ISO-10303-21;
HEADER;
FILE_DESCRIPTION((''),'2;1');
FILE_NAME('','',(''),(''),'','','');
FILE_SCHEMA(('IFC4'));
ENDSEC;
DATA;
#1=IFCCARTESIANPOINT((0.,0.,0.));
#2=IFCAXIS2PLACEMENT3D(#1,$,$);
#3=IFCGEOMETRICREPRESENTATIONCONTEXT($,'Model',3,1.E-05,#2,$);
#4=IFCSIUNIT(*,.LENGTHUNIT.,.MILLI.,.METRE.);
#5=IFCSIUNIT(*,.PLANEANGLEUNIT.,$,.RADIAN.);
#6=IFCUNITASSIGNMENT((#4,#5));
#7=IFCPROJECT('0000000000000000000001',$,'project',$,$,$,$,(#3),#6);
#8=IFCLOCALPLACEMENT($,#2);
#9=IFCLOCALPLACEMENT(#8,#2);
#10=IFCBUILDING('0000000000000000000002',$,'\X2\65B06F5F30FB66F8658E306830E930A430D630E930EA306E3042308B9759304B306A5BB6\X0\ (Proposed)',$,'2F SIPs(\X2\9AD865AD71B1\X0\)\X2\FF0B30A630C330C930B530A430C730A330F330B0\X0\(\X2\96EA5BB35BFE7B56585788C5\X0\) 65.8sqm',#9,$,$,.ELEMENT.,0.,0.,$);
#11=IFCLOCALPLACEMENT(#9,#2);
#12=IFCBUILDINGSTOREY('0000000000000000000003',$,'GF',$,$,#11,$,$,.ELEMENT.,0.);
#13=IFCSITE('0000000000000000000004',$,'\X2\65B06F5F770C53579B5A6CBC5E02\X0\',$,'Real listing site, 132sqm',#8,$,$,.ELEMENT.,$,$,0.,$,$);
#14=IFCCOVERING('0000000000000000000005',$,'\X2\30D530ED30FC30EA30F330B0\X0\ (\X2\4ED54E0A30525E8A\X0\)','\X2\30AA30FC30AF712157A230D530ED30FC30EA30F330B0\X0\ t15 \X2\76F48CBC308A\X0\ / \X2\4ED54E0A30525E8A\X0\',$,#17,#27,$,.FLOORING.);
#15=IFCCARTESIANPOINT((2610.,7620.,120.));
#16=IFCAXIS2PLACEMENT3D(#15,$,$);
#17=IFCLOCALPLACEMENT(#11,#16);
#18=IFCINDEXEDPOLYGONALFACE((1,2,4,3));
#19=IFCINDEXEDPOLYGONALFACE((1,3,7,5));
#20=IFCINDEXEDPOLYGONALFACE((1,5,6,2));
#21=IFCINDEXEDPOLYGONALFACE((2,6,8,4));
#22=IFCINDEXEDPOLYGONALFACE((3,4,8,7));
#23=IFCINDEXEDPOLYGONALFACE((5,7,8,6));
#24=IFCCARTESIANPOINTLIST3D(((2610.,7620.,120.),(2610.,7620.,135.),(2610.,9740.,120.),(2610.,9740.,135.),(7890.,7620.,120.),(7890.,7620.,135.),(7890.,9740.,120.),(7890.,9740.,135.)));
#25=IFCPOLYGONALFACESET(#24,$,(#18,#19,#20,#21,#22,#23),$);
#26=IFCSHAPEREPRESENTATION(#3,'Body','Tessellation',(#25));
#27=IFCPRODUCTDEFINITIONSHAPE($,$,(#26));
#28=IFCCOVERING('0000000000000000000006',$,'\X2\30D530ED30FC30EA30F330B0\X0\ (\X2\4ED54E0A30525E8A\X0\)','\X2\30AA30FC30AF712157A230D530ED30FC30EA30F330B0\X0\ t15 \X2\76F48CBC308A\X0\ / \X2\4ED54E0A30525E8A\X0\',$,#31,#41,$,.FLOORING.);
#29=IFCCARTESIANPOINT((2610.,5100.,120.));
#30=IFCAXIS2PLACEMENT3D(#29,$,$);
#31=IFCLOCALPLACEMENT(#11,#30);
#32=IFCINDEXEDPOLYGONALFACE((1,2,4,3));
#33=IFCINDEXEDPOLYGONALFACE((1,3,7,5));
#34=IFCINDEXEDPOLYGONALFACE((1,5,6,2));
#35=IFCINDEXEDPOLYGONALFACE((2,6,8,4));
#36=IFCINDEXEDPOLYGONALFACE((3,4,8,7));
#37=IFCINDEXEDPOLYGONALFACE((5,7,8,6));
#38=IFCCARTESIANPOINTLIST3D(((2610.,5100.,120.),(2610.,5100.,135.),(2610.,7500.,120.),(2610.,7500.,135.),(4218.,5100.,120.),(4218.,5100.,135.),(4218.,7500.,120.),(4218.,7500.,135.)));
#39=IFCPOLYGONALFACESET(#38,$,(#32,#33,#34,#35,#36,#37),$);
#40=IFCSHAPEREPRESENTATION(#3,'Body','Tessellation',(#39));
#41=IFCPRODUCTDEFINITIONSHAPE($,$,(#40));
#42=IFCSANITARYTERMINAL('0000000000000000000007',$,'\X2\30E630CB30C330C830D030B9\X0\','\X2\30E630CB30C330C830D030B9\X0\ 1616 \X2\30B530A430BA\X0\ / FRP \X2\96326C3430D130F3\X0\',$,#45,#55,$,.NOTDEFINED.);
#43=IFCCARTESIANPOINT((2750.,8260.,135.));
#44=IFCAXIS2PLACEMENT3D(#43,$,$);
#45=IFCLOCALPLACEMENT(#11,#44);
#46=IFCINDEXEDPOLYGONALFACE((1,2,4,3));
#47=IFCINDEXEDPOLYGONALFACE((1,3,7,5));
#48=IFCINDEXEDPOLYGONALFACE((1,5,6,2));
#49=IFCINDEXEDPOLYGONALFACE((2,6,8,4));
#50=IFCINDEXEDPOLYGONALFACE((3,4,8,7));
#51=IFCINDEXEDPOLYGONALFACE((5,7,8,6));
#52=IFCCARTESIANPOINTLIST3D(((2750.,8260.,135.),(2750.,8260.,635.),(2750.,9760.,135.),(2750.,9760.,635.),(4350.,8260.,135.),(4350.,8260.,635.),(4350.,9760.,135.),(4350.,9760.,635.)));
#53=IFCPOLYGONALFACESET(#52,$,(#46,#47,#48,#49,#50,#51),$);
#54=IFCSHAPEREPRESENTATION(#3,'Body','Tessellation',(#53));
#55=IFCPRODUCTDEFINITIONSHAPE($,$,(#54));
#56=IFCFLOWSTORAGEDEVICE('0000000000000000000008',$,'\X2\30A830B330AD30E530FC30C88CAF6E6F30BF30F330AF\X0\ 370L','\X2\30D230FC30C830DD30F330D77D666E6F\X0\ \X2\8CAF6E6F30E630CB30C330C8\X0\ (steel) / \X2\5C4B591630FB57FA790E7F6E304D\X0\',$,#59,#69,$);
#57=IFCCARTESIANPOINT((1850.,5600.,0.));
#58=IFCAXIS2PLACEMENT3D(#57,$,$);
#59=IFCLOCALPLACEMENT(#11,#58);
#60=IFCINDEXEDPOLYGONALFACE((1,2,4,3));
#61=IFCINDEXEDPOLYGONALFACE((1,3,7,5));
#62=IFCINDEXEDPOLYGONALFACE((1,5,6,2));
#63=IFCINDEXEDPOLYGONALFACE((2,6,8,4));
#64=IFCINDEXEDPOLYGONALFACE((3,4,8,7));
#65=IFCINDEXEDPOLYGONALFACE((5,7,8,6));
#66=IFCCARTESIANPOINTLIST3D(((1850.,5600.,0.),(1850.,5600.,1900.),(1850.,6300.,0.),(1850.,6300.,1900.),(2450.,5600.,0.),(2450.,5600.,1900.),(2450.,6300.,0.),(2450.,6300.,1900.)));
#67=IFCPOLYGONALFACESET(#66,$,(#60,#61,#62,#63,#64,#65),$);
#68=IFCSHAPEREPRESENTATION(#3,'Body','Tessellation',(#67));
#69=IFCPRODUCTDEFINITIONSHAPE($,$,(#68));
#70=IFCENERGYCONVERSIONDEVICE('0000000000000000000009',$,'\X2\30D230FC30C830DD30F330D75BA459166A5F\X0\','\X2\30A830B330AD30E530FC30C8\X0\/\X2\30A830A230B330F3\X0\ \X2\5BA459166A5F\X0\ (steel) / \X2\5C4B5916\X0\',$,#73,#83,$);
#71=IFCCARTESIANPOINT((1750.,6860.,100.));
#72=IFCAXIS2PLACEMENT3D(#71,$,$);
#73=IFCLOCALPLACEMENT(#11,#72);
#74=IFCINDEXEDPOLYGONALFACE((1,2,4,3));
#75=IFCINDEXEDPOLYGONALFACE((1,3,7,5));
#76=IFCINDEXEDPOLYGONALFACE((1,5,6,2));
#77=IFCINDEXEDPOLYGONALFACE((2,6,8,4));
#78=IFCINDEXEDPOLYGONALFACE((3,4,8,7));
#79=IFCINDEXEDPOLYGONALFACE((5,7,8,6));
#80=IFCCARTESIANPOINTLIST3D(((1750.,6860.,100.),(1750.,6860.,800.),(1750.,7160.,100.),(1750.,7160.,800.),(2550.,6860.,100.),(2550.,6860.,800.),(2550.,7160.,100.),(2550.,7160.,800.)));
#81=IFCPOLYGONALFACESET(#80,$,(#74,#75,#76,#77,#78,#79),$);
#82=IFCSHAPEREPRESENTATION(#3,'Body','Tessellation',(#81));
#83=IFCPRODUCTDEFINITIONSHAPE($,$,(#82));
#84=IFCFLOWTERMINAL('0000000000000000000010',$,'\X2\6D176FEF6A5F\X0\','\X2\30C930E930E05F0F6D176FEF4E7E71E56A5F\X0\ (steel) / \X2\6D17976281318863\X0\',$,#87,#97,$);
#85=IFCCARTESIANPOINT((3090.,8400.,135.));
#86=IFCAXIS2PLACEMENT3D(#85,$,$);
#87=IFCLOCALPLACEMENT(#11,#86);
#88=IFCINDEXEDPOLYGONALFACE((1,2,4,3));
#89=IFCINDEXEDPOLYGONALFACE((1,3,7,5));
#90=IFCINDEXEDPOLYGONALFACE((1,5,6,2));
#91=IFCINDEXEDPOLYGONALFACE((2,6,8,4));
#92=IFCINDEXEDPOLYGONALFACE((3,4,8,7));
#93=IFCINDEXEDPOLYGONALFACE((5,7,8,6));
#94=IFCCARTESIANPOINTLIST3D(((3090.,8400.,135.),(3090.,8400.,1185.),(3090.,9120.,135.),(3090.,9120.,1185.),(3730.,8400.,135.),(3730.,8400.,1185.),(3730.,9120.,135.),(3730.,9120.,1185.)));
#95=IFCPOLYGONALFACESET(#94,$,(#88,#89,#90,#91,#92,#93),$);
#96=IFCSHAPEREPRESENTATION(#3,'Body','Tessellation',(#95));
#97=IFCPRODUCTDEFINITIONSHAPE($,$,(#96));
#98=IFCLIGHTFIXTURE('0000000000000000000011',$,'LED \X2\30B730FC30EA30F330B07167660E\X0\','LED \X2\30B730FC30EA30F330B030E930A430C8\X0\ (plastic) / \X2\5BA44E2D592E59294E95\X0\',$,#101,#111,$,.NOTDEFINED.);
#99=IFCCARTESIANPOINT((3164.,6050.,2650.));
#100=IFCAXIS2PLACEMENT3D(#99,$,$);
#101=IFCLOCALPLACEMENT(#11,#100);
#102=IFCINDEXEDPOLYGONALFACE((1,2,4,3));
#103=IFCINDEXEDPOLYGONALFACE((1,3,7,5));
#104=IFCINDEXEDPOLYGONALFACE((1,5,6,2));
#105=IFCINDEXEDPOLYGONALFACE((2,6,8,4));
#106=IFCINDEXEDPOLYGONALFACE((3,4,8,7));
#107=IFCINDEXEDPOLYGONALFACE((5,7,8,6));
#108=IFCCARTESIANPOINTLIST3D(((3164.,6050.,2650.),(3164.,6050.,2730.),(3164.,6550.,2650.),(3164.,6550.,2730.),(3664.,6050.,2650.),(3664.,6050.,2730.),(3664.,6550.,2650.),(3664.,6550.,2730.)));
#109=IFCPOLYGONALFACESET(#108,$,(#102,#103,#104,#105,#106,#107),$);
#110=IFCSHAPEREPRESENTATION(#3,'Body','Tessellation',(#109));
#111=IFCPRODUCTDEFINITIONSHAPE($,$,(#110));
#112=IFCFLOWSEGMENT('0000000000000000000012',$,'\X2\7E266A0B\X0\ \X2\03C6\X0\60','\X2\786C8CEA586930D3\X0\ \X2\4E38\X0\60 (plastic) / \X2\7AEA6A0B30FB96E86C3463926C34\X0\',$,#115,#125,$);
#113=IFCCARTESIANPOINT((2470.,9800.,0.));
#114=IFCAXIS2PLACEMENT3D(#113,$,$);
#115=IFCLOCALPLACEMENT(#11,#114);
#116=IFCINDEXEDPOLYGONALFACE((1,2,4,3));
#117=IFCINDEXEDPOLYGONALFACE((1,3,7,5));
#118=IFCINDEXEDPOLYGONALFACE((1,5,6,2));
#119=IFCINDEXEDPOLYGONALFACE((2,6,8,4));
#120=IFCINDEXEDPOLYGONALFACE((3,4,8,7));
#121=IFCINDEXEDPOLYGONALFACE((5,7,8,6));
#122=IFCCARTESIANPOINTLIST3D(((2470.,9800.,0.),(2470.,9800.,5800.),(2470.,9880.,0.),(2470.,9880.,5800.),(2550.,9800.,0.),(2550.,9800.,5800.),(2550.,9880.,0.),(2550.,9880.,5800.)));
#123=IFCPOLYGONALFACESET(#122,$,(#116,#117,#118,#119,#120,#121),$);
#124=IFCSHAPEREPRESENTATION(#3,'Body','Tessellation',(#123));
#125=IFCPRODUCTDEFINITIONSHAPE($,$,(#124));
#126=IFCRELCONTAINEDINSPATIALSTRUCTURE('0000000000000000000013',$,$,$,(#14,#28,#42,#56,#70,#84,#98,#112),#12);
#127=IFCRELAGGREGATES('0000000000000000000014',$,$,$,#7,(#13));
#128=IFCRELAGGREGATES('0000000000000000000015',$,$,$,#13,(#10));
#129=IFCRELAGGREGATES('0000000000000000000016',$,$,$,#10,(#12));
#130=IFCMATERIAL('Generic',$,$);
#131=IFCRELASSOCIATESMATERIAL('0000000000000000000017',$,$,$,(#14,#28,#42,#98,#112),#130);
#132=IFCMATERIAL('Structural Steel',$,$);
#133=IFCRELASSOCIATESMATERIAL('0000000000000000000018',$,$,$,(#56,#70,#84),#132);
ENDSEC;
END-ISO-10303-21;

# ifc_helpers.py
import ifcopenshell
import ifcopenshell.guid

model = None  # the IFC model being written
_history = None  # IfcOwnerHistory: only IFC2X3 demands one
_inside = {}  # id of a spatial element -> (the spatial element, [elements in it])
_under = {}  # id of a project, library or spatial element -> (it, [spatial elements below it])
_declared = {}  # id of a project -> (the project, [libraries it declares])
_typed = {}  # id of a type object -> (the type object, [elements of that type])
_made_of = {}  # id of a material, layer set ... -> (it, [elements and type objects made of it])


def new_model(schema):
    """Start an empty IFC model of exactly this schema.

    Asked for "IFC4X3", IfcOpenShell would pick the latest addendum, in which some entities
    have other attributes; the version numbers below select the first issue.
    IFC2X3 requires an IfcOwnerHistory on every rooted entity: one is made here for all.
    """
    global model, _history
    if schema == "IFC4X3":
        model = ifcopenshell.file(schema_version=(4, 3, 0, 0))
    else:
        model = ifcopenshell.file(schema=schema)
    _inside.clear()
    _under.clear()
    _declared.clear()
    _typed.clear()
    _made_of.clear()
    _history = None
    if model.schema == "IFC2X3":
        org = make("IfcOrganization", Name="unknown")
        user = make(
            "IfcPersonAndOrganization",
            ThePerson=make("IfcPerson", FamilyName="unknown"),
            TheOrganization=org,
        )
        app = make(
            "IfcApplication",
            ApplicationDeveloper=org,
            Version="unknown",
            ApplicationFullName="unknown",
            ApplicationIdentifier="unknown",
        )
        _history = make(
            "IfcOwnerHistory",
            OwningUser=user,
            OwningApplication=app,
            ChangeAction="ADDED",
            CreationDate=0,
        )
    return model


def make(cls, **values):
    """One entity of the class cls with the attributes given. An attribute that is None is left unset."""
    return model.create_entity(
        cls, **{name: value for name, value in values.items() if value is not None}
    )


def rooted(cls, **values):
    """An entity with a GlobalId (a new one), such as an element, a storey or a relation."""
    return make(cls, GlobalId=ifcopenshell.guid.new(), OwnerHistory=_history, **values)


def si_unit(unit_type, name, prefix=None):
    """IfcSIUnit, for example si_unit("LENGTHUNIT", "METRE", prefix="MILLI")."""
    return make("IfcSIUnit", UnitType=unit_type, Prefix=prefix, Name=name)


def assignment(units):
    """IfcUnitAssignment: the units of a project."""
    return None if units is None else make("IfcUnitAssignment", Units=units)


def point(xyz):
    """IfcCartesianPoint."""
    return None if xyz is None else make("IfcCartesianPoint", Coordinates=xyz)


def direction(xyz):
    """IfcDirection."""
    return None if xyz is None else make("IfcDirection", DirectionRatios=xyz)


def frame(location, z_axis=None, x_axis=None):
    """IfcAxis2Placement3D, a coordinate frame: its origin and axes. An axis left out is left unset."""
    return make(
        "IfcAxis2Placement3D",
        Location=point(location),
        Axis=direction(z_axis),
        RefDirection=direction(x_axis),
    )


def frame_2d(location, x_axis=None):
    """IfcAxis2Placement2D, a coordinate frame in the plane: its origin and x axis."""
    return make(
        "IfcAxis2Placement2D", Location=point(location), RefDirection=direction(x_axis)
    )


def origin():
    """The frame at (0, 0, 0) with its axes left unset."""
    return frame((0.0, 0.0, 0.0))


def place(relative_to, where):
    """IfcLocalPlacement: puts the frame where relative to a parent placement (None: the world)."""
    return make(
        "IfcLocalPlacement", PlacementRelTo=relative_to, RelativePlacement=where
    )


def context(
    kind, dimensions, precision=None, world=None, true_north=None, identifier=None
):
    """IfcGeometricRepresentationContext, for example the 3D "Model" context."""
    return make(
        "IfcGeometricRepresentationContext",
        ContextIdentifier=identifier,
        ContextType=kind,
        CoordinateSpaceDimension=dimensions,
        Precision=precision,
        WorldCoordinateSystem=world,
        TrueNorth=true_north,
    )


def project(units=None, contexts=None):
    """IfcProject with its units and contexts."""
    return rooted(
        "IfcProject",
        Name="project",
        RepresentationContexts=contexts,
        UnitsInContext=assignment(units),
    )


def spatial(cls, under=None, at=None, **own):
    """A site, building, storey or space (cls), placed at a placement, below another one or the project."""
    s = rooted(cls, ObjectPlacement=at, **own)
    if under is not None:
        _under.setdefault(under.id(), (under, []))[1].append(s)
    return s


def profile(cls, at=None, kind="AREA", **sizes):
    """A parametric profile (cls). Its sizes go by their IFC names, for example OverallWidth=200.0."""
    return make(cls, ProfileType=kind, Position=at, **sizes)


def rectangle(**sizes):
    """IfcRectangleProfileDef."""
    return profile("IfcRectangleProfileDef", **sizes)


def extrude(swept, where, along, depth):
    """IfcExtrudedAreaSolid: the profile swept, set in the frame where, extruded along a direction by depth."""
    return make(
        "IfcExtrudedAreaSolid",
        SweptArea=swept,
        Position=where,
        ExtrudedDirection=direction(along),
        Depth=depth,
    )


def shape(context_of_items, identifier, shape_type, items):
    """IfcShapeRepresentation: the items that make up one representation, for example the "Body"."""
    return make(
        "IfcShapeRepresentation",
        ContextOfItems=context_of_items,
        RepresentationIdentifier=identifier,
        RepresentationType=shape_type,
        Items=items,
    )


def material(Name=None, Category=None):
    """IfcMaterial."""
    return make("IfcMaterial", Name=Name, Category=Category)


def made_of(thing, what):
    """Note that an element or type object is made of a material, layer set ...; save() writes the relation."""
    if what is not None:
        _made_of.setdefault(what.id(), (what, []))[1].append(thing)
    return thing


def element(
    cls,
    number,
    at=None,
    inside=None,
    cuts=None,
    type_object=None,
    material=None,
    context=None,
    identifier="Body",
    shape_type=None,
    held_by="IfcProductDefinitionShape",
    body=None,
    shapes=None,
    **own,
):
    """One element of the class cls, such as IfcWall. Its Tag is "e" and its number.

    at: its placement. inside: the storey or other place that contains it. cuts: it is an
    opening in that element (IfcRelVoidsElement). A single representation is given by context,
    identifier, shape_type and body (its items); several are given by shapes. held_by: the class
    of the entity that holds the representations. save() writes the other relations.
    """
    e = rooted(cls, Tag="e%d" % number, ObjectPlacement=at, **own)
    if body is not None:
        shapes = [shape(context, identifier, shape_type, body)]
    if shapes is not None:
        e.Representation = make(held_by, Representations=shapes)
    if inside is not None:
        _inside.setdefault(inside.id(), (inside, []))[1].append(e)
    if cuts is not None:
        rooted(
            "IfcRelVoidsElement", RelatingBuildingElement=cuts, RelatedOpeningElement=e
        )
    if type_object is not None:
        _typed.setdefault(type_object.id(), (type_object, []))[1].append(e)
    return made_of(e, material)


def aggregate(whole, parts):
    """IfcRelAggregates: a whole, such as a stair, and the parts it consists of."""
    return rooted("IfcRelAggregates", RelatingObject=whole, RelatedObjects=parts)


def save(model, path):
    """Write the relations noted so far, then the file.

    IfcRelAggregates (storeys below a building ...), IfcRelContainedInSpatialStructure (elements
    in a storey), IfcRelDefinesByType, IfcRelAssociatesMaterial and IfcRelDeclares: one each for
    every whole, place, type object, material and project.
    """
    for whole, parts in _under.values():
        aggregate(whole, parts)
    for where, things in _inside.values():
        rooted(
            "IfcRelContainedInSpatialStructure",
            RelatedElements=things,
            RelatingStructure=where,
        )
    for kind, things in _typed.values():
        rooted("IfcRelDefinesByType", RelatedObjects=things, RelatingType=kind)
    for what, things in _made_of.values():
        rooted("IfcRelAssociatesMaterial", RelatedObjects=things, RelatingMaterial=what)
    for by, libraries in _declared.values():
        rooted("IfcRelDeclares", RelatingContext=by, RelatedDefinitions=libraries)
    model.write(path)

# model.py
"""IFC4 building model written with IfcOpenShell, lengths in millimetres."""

from ifc_helpers import new_model, si_unit, frame, frame_2d, origin, place, context, project, spatial, rectangle, extrude, material, element, save


model = new_model("IFC4")

# Units and contexts
model_context = context("Model", 3, precision=1e-05, world=origin())
ifc_project = project(units=[si_unit("LENGTHUNIT", "METRE", prefix="MILLI"), si_unit("PLANEANGLEUNIT", "RADIAN")], contexts=[model_context])

# Site, building, storey
site_placement = place(None, origin())
site = spatial("IfcSite", under=ifc_project, at=site_placement, Name="新潟県南魚沼市", ObjectType="Real listing site, 132sqm", CompositionType="ELEMENT", RefElevation=0.0)
building_placement = place(site_placement, origin())
building = spatial("IfcBuilding", under=site, at=building_placement, Name="新潟・書斎とライブラリのある静かな家 (Proposed)", ObjectType="2F SIPs(高断熱)＋ウッドサイディング(雪害対策塗装) 65.8sqm", CompositionType="ELEMENT", ElevationOfRefHeight=0.0, ElevationOfTerrain=0.0)
storey_placement = place(building_placement, origin())
storey = spatial("IfcBuildingStorey", under=building, at=storey_placement, Name="GF", CompositionType="ELEMENT", Elevation=0.0)

# Coverings
ifc_material_1 = material(Name="Generic")
covering_1_placement = place(storey_placement, frame((2610.0, 7620.0, 120.0)))
element("IfcCovering", 1, at=covering_1_placement, inside=storey, material=ifc_material_1, Name="フローリング (仕上げ床)", Description="オーク無垢フローリング t15 直貼り / 仕上げ床", PredefinedType="FLOORING", context=model_context, shape_type="SweptSolid", body=[
    extrude(rectangle(XDim=5280.0, YDim=2120.0, at=frame_2d((2640.0, 1060.0))), frame((2610.0, 7620.0, 120.0)), (0.0, 0.0, 1.0), 15.0),
])
covering_2_placement = place(storey_placement, frame((2610.0, 5100.0, 120.0)))
element("IfcCovering", 2, at=covering_2_placement, inside=storey, material=ifc_material_1, Name="フローリング (仕上げ床)", Description="オーク無垢フローリング t15 直貼り / 仕上げ床", PredefinedType="FLOORING", context=model_context, shape_type="SweptSolid", body=[
    extrude(rectangle(XDim=1608.0, YDim=2400.0, at=frame_2d((804.0, 1200.0))), frame((2610.0, 5100.0, 120.0)), (0.0, 0.0, 1.0), 15.0),
])

# Sanitary terminal
sanitary_terminal_placement = place(storey_placement, frame((2750.0, 8260.0, 135.0)))
element("IfcSanitaryTerminal", 3, at=sanitary_terminal_placement, inside=storey, material=ifc_material_1, Name="ユニットバス", Description="ユニットバス 1616 サイズ / FRP 防水パン", PredefinedType="NOTDEFINED", context=model_context, shape_type="SweptSolid", body=[
    extrude(rectangle(XDim=1600.0, YDim=1500.0, at=frame_2d((800.0, 750.0))), frame((2750.0, 8260.0, 135.0)), (0.0, 0.0, 1.0), 500.0),
])

# Flow storage device
ifc_material_2 = material(Name="Structural Steel")
flow_storage_device_placement = place(storey_placement, frame((1850.0, 5600.0, 0.0)))
element("IfcFlowStorageDevice", 4, at=flow_storage_device_placement, inside=storey, material=ifc_material_2, Name="エコキュート貯湯タンク 370L", Description="ヒートポンプ給湯 貯湯ユニット (steel) / 屋外・基礎置き", context=model_context, shape_type="SweptSolid", body=[
    extrude(rectangle(XDim=600.0, YDim=700.0, at=frame_2d((300.0, 350.0))), frame((1850.0, 5600.0, 0.0)), (0.0, 0.0, 1.0), 1900.0),
])

# Energy conversion device
energy_conversion_device_placement = place(storey_placement, frame((1750.0, 6860.0, 100.0)))
element("IfcEnergyConversionDevice", 5, at=energy_conversion_device_placement, inside=storey, material=ifc_material_2, Name="ヒートポンプ室外機", Description="エコキュート/エアコン 室外機 (steel) / 屋外", context=model_context, shape_type="SweptSolid", body=[
    extrude(rectangle(XDim=800.0, YDim=300.0, at=frame_2d((400.0, 150.0))), frame((1750.0, 6860.0, 100.0)), (0.0, 0.0, 1.0), 700.0),
])

# Flow terminal
flow_terminal_placement = place(storey_placement, frame((3090.0, 8400.0, 135.0)))
element("IfcFlowTerminal", 6, at=flow_terminal_placement, inside=storey, material=ifc_material_2, Name="洗濯機", Description="ドラム式洗濯乾燥機 (steel) / 洗面脱衣", context=model_context, shape_type="SweptSolid", body=[
    extrude(rectangle(XDim=640.0, YDim=720.0, at=frame_2d((320.0, 360.0))), frame((3090.0, 8400.0, 135.0)), (0.0, 0.0, 1.0), 1050.0),
])

# Light fixture
light_fixture_placement = place(storey_placement, frame((3164.0, 6050.0, 2650.0)))
element("IfcLightFixture", 7, at=light_fixture_placement, inside=storey, material=ifc_material_1, Name="LED シーリング照明", Description="LED シーリングライト (plastic) / 室中央天井", PredefinedType="NOTDEFINED", context=model_context, shape_type="SweptSolid", body=[
    extrude(rectangle(XDim=500.0, YDim=500.0, at=frame_2d((250.0, 250.0))), frame((3164.0, 6050.0, 2650.0)), (0.0, 0.0, 1.0), 80.0),
])

# Flow segment
flow_segment_placement = place(storey_placement, frame((2470.0, 9800.0, 0.0)))
element("IfcFlowSegment", 8, at=flow_segment_placement, inside=storey, material=ifc_material_1, Name="縦樋 φ60", Description="硬質塩ビ 丸60 (plastic) / 竪樋・雨水排水", context=model_context, shape_type="SweptSolid", body=[
    extrude(rectangle(XDim=80.0, YDim=80.0, at=frame_2d((40.0, 40.0))), frame((2470.0, 9800.0, 0.0)), (0.0, 0.0, 1.0), 5800.0),
])

save(model, "model.ifc")
